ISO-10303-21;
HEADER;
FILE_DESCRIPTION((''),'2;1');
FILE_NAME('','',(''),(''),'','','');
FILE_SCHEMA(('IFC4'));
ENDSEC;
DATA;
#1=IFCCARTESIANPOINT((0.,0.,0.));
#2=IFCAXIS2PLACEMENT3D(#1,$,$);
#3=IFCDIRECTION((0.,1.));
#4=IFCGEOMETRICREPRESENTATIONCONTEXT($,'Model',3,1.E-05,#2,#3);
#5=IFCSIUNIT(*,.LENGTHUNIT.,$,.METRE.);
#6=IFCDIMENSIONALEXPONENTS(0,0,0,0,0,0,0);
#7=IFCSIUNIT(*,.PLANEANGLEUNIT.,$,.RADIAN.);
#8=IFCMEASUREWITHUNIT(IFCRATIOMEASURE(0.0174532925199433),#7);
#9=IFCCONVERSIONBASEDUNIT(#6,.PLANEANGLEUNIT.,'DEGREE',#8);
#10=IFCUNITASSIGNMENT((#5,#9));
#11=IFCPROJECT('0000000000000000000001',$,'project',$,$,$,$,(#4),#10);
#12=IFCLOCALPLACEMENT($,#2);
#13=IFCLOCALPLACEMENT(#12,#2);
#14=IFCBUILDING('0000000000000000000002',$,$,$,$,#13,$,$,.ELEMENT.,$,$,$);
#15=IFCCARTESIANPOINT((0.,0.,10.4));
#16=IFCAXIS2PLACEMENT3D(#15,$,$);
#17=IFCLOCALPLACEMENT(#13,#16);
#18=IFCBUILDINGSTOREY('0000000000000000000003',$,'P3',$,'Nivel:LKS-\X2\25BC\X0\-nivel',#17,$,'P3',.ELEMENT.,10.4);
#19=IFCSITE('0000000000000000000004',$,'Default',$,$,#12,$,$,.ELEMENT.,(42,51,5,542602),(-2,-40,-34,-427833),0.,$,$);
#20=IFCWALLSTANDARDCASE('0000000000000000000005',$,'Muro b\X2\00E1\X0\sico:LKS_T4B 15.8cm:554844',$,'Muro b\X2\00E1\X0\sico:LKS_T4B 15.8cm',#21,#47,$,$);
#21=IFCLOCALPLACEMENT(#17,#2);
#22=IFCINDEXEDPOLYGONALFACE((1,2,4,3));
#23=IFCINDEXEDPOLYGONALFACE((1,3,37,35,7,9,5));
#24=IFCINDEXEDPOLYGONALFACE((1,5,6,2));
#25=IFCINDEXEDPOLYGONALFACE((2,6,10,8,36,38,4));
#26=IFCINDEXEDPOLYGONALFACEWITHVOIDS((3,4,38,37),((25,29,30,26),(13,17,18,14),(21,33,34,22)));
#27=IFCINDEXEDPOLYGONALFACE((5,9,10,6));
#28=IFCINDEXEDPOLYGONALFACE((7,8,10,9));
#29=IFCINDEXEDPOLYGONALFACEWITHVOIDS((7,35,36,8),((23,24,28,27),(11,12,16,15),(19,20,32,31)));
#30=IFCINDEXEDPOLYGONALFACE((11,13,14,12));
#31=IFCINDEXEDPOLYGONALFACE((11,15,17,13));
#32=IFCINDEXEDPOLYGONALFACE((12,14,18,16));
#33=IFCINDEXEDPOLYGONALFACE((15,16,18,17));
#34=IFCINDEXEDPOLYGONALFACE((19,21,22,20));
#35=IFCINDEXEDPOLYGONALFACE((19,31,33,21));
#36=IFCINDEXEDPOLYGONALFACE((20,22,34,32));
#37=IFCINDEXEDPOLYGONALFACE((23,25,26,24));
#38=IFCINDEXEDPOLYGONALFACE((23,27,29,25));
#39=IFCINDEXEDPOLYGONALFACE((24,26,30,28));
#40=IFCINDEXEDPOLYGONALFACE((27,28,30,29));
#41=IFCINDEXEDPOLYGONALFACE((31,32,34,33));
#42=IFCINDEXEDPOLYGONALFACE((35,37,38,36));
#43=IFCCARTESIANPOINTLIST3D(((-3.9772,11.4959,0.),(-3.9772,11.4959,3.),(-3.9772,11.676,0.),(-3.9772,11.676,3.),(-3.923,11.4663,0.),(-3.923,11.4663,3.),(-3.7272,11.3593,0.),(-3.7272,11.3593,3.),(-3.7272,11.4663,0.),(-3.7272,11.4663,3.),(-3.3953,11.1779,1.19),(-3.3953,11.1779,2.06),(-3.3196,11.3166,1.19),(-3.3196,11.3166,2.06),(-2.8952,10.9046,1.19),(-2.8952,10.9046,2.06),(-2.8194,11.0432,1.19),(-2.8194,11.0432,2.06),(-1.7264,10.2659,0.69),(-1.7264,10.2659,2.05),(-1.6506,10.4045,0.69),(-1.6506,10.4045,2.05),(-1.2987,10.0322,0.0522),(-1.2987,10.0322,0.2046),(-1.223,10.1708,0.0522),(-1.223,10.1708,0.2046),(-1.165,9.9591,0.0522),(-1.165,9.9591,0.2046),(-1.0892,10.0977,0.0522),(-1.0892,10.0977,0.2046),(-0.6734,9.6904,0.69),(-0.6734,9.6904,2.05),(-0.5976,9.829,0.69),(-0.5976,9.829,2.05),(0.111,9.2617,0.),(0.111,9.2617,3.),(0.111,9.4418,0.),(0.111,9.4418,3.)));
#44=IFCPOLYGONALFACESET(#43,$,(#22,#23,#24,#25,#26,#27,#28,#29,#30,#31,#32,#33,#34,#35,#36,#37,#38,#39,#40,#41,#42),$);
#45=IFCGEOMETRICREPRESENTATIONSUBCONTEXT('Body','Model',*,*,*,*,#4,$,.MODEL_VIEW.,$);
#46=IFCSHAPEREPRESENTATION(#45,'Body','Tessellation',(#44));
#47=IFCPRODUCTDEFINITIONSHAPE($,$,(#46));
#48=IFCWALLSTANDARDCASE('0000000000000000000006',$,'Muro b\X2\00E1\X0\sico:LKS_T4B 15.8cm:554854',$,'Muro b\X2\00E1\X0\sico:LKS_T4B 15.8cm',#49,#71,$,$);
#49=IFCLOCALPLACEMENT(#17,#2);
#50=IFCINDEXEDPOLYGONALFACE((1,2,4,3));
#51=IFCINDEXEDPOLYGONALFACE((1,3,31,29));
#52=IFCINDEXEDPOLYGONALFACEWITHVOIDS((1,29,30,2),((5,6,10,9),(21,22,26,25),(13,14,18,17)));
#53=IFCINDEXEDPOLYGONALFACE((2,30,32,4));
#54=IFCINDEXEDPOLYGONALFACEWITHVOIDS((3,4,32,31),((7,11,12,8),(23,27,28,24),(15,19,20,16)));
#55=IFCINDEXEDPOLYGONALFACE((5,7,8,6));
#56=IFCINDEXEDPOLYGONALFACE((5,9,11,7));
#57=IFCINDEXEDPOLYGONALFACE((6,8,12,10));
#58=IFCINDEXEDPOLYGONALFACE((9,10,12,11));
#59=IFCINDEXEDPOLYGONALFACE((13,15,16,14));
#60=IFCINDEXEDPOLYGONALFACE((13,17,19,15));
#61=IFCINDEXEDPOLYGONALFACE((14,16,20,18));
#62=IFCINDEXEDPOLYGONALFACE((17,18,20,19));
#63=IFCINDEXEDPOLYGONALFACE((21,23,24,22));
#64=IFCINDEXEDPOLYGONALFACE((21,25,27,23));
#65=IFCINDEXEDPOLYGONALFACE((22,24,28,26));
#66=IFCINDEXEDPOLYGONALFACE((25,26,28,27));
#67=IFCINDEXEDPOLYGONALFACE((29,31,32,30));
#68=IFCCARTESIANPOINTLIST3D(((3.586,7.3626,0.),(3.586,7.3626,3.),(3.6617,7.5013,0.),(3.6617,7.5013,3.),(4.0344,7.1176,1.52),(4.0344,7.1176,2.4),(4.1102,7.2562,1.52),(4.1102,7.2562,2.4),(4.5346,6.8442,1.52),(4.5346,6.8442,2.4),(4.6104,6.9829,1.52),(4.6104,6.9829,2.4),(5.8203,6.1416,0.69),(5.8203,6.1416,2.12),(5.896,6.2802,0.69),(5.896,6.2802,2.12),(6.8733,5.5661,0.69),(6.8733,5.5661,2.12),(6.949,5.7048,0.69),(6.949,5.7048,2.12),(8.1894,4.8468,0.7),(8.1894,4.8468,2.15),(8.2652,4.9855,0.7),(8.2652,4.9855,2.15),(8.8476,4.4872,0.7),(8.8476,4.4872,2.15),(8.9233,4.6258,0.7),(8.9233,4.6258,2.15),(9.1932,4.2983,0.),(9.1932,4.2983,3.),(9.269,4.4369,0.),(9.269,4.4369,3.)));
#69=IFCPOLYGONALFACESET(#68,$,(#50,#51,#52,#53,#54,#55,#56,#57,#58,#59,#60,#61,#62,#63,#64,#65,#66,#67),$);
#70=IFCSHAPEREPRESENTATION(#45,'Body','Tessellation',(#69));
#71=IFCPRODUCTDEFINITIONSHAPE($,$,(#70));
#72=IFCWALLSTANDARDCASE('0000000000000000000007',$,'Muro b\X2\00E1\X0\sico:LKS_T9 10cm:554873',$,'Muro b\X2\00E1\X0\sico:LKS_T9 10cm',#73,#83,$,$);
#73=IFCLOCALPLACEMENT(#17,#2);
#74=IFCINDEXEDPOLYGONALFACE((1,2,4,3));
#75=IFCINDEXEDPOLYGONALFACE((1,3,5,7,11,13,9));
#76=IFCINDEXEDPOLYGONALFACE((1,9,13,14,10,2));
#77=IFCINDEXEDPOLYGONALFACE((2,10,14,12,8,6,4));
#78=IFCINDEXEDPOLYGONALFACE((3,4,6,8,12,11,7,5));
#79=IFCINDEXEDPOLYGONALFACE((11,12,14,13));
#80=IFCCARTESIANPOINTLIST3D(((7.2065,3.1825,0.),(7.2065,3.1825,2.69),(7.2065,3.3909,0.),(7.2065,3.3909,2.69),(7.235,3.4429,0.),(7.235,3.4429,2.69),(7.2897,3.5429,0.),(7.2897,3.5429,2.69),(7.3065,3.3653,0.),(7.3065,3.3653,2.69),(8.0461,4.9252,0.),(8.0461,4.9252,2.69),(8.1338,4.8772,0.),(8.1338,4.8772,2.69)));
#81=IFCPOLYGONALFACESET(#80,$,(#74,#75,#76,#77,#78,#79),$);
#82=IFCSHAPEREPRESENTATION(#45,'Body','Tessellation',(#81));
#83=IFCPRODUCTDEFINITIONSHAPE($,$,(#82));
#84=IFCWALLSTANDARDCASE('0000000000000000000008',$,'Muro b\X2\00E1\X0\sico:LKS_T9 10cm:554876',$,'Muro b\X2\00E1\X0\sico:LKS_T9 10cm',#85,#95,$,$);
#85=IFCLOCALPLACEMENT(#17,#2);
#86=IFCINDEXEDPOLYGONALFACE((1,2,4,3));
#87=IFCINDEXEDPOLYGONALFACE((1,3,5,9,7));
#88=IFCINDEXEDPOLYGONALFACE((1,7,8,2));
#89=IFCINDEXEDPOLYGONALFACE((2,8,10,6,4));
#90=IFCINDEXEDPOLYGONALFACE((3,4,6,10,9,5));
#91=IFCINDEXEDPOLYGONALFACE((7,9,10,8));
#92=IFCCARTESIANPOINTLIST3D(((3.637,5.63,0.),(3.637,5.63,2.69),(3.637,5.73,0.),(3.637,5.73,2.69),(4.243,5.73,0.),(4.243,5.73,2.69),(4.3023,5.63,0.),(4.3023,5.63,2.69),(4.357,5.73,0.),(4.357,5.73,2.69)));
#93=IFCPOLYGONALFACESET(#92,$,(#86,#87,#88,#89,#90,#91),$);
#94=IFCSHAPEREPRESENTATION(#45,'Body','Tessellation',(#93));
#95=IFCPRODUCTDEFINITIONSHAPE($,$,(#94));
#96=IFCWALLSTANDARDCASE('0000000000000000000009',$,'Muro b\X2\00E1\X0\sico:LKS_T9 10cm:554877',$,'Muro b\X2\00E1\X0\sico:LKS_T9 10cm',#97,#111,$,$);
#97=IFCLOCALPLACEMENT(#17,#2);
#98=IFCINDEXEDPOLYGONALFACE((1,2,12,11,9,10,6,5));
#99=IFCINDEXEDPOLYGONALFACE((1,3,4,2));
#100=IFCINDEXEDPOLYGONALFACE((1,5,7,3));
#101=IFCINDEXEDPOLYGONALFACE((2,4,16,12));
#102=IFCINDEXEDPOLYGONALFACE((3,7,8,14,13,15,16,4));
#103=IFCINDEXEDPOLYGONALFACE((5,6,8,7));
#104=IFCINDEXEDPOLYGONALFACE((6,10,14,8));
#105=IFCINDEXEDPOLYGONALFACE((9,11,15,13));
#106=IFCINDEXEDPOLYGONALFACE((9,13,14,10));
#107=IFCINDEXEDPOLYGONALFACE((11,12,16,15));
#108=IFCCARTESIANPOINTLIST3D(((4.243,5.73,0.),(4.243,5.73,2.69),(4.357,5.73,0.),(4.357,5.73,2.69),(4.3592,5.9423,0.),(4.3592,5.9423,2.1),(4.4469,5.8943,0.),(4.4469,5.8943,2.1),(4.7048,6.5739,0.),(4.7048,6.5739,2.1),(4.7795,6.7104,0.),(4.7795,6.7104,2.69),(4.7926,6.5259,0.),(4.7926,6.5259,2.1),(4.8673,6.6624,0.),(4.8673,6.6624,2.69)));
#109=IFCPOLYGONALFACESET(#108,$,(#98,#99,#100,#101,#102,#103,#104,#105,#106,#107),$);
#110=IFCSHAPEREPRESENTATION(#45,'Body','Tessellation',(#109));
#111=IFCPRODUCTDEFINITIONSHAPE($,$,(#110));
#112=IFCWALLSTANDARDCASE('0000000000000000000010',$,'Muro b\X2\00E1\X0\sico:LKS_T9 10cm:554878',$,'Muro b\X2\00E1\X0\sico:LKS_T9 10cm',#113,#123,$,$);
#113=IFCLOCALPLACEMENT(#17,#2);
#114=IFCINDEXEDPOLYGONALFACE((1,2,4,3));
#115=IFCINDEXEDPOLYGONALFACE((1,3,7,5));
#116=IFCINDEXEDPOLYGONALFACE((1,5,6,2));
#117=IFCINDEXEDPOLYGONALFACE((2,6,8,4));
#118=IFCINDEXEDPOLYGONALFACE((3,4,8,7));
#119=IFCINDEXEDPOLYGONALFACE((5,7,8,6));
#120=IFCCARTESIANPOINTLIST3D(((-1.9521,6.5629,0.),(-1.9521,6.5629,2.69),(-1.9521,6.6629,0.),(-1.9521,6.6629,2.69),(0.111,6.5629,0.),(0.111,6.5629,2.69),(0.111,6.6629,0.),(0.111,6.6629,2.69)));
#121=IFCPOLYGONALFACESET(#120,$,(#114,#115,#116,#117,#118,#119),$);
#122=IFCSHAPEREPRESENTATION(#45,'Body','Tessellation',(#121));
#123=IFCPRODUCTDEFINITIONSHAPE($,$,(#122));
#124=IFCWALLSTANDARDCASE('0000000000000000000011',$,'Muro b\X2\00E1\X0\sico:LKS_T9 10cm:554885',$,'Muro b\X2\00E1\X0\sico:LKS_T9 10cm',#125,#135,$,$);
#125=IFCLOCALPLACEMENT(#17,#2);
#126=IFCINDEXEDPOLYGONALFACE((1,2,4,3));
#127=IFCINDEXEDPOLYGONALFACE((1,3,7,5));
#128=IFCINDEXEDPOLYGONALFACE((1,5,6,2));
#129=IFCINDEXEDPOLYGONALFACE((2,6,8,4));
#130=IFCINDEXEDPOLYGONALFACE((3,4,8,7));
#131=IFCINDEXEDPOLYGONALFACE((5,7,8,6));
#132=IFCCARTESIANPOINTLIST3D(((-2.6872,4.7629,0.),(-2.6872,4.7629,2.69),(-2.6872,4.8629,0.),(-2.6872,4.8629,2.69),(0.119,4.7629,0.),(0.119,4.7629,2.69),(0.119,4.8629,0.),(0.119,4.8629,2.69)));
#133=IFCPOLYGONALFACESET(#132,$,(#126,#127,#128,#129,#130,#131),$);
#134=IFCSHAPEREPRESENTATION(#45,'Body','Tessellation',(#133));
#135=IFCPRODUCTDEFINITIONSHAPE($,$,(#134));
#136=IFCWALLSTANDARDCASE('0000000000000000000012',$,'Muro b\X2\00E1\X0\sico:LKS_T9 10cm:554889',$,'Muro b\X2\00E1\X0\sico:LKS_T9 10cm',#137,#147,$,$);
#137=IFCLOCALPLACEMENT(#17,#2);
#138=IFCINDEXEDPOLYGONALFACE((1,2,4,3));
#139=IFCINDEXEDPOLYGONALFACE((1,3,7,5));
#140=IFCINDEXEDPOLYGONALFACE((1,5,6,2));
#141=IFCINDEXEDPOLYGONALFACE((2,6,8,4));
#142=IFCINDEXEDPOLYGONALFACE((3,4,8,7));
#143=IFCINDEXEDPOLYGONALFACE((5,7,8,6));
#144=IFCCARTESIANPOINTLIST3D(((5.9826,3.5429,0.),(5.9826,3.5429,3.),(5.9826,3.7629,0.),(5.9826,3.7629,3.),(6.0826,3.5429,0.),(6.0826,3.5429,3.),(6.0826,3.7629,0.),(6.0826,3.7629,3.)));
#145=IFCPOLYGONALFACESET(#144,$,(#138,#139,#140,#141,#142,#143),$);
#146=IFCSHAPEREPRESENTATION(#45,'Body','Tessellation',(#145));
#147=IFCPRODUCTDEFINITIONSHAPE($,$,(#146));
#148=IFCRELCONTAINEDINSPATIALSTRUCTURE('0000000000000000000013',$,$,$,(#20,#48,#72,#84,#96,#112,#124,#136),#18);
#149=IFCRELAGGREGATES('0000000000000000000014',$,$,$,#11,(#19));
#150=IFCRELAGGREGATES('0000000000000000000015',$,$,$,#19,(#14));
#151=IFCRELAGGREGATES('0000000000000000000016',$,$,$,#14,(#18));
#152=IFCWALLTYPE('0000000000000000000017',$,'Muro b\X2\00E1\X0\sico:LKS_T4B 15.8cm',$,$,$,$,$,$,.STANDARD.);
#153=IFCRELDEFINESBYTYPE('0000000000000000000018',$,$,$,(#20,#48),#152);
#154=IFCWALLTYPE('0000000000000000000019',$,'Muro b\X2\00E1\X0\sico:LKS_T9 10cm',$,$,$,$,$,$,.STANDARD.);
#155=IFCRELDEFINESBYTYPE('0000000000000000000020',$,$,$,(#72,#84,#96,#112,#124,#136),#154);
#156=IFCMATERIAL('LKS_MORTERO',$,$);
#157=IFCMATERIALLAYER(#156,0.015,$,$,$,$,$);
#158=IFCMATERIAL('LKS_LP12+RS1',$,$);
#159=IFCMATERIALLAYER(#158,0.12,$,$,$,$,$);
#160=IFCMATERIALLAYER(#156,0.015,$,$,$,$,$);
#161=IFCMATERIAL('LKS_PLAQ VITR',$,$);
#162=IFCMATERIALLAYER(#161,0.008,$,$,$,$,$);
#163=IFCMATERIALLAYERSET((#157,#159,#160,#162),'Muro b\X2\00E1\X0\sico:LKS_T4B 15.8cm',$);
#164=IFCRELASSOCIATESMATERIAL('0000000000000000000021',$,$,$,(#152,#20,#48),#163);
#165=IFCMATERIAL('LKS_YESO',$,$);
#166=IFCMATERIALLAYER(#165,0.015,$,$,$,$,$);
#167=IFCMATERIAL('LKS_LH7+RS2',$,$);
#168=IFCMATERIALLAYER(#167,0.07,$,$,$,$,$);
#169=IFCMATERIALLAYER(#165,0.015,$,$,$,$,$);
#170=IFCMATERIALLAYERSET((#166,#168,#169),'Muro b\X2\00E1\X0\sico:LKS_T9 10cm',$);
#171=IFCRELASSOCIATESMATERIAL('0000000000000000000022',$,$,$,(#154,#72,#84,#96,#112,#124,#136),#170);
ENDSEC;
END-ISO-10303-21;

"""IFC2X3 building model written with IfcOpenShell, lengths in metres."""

from ifc_helpers import new_model, entity, si_unit, converted_unit, direction, frame, frame_2d, origin, place, context, subcontext, project, spatial, polyline, rectangle, outline, extrude, clip, bounded_halfspace, material, layer, layer_set, layer_usage, type_object, element, save


model = new_model("IFC2X3")

# Units and contexts
model_context = context("Model", 3, precision=1e-05, world=origin(), true_north=direction((0.0, 1.0)))
body_context = subcontext(model_context, "Body", "Model", "MODEL_VIEW")
ifc_project = project(units=[si_unit("LENGTHUNIT", "METRE"), converted_unit("PLANEANGLEUNIT", "DEGREE", entity("IfcRatioMeasure", 0.0174532925199433), si_unit("PLANEANGLEUNIT", "RADIAN"), dimensions=[0, 0, 0, 0, 0, 0, 0])], contexts=[model_context])

# Site, building, storey
site_placement = place(None, origin())
site = spatial("IfcSite", under=ifc_project, at=site_placement, Name="Default", CompositionType="ELEMENT", RefLatitude=(42, 51, 5, 542602), RefLongitude=(-2, -40, -34, -427833), RefElevation=0.0)
building_placement = place(site_placement, origin())
building = spatial("IfcBuilding", under=site, at=building_placement, CompositionType="ELEMENT")
storey_placement = place(building_placement, frame((0.0, 0.0, 10.4)))
storey = spatial("IfcBuildingStorey", under=building, at=storey_placement, Name="P3", ObjectType="Nivel:LKS-▼-nivel", LongName="P3", CompositionType="ELEMENT", Elevation=10.4)

# Walls, openings
ifc_material_1 = material(Name="LKS_MORTERO")
ifc_layer_1 = layer(ifc_material_1, 0.015)
ifc_material_2 = material(Name="LKS_LP12+RS1")
ifc_layer_2 = layer(ifc_material_2, 0.12)
ifc_layer_3 = layer(ifc_material_1, 0.015)
ifc_material_3 = material(Name="LKS_PLAQ VITR")
ifc_layer_4 = layer(ifc_material_3, 0.008)
ifc_layer_set_1 = layer_set([ifc_layer_1, ifc_layer_2, ifc_layer_3, ifc_layer_4], Name="Muro básico:LKS_T4B 15.8cm")
ifc_layer_usage_1 = layer_usage(ifc_layer_set_1, "AXIS2", "NEGATIVE", 0.079)
wall_type_1 = type_object("IfcWallType", Name="Muro básico:LKS_T4B 15.8cm", PredefinedType="STANDARD", material=ifc_layer_set_1)
wall_1_placement = place(storey_placement, frame((0.1488, 9.3311, 0.0), z_axis=(0.0, 0.0, 1.0), x_axis=(-0.877509, 0.479561, 0.0)))
wall_1 = element("IfcWallStandardCase", 1, at=wall_1_placement, inside=storey, type_object=wall_type_1, material=ifc_layer_usage_1, Name="Muro básico:LKS_T4B 15.8cm:554844", ObjectType="Muro básico:LKS_T4B 15.8cm", context=body_context, shape_type="Clipping", body=[
    clip(clip(extrude(outline(polyline([(4.7451, -0.079), (4.6588, 0.079), (4.5971, 0.079), (4.4252, -0.0149), (4.3739, 0.079), (2.8965, 0.079), (2.7965, 0.079), (0.0, 0.079), (0.0863, -0.079), (4.7451, -0.079)])), origin(), (0.0, 0.0, 1.0), 3.0), bounded_halfspace(frame((4.4252, -0.0149, 3.0), z_axis=(-0.877509, -0.479561, 0.0), x_axis=(0.0, 0.0, -1.0)), True, frame((4.4252, -0.0149, 3.0), z_axis=(-0.877509, -0.479561, 0.0), x_axis=(0.0, 0.0, -1.0)), polyline([(0.0, 0.0), (0.0, -0.107), (3.0, -0.107), (3.0, 0.0), (0.33, 0.0), (0.0, 0.0)]))), bounded_halfspace(frame((4.4252, -0.0149, 0.0), z_axis=(0.479561, -0.877509, 0.0), x_axis=(0.0, 0.0, -1.0)), True, frame((4.4252, -0.0149, 0.0), z_axis=(0.479561, -0.877509, 0.0), x_axis=(0.0, 0.0, -1.0)), polyline([(0.0, 0.0), (0.0, 0.1959), (-3.0, 0.1959), (-3.0, 0.0), (-2.67, 0.0), (0.0, 0.0)]))),
])
opening_1_placement = place(wall_1_placement, origin())
element("IfcOpeningElement", 2, at=opening_1_placement, cuts=wall_1, ObjectType="Opening", context=body_context, shape_type="SweptSolid", body=[
    extrude(rectangle(XDim=0.1524, YDim=0.1524, at=frame_2d((0.0, 0.0), x_axis=(0.0, 1.0))), frame((1.5303, -1.445, 0.1284), z_axis=(0.0, 1.0, 0.0), x_axis=(-1.0, 0.0, 0.0)), (0.0, 0.0, 1.0), 3.048),
])
opening_2_placement = place(wall_1_placement, frame((2.0939, 0.079, 0.69)))
element("IfcOpeningElement", 3, at=opening_2_placement, cuts=wall_1, ObjectType="Opening", context=body_context, shape_type="SweptSolid", body=[
    extrude(rectangle(XDim=1.36, YDim=1.2, at=frame_2d((0.68, 0.6), x_axis=(1.0, 0.0))), frame((0.0, 0.0, 0.0), z_axis=(0.0, -1.0, 0.0), x_axis=(0.0, 0.0, 1.0)), (0.0, 0.0, 1.0), 0.158),
])
opening_3_placement = place(wall_1_placement, frame((3.9957, 0.079, 1.19)))
element("IfcOpeningElement", 4, at=opening_3_placement, cuts=wall_1, ObjectType="Opening", context=body_context, shape_type="SweptSolid", body=[
    extrude(rectangle(XDim=0.87, YDim=0.57, at=frame_2d((0.435, 0.285), x_axis=(1.0, 0.0))), frame((0.0, 0.0, 0.0), z_axis=(0.0, -1.0, 0.0), x_axis=(0.0, 0.0, 1.0)), (0.0, 0.0, 1.0), 0.158),
])
ifc_layer_usage_2 = layer_usage(ifc_layer_set_1, "AXIS2", "POSITIVE", -0.079)
wall_2_placement = place(storey_placement, frame((9.2311, 4.3676, 0.0), z_axis=(0.0, 0.0, 1.0), x_axis=(-0.877509, 0.479561, 0.0)))
wall_2 = element("IfcWallStandardCase", 5, at=wall_2_placement, inside=storey, type_object=wall_type_1, material=ifc_layer_usage_2, Name="Muro básico:LKS_T4B 15.8cm:554854", ObjectType="Muro básico:LKS_T4B 15.8cm", context=body_context, shape_type="Clipping", body=[
    clip(clip(extrude(rectangle(XDim=6.39, YDim=0.158, at=frame_2d((3.195, 0.0), x_axis=(-1.0, 0.0))), origin(), (0.0, 0.0, 1.0), 3.0), bounded_halfspace(frame((6.39, -0.079, 3.0), z_axis=(-1.0, 0.0, 0.0), x_axis=(0.0, 0.0, -1.0)), True, frame((6.39, -0.079, 3.0), z_axis=(-1.0, 0.0, 0.0), x_axis=(0.0, 0.0, -1.0)), polyline([(0.0, 0.0), (0.0, -0.0455), (0.0, -0.158), (3.0, -0.158), (3.0, 0.0), (0.0, 0.0)]))), bounded_halfspace(frame((0.0, -0.079, 0.0), z_axis=(1.0, 0.0, 0.0), x_axis=(0.0, 0.0, -1.0)), True, frame((0.0, -0.079, 0.0), z_axis=(1.0, 0.0, 0.0), x_axis=(0.0, 0.0, -1.0)), polyline([(0.0, 0.0), (0.0, 0.158), (-3.0, 0.158), (-3.0, 0.0488), (-3.0, 0.0), (0.0, 0.0)]))),
])
opening_4_placement = place(wall_2_placement, frame((3.8438, 0.079, 0.69)))
element("IfcOpeningElement", 6, at=opening_4_placement, cuts=wall_2, ObjectType="Opening", context=body_context, shape_type="SweptSolid", body=[
    extrude(rectangle(XDim=1.43, YDim=1.2, at=frame_2d((0.715, 0.6), x_axis=(1.0, 0.0))), frame((0.0, 0.0, 0.0), z_axis=(0.0, -1.0, 0.0), x_axis=(0.0, 0.0, 1.0)), (0.0, 0.0, 1.0), 0.158),
])
opening_5_placement = place(wall_2_placement, frame((5.8789, 0.079, 1.52)))
element("IfcOpeningElement", 7, at=opening_5_placement, cuts=wall_2, ObjectType="Opening", context=body_context, shape_type="SweptSolid", body=[
    extrude(rectangle(XDim=0.88, YDim=0.57, at=frame_2d((0.44, 0.285), x_axis=(1.0, 0.0))), frame((0.0, 0.0, 0.0), z_axis=(0.0, -1.0, 0.0), x_axis=(0.0, 0.0, 1.0)), (0.0, 0.0, 1.0), 0.158),
])
opening_6_placement = place(wall_2_placement, frame((1.1439, 0.079, 0.7)))
element("IfcOpeningElement", 8, at=opening_6_placement, cuts=wall_2, ObjectType="Opening", context=body_context, shape_type="SweptSolid", body=[
    extrude(rectangle(XDim=1.45, YDim=0.75, at=frame_2d((0.725, 0.375), x_axis=(1.0, 0.0))), frame((0.0, 0.0, 0.0), z_axis=(0.0, -1.0, 0.0), x_axis=(0.0, 0.0, 1.0)), (0.0, 0.0, 1.0), 0.158),
])

# Walls
ifc_material_4 = material(Name="LKS_YESO")
ifc_layer_5 = layer(ifc_material_4, 0.015)
ifc_material_5 = material(Name="LKS_LH7+RS2")
ifc_layer_6 = layer(ifc_material_5, 0.07)
ifc_layer_7 = layer(ifc_material_4, 0.015)
ifc_layer_set_2 = layer_set([ifc_layer_5, ifc_layer_6, ifc_layer_7], Name="Muro básico:LKS_T9 10cm")
ifc_layer_usage_3 = layer_usage(ifc_layer_set_2, "AXIS2", "NEGATIVE", 0.05)
wall_type_2 = type_object("IfcWallType", Name="Muro básico:LKS_T9 10cm", PredefinedType="STANDARD", material=ifc_layer_set_2)
wall_3_placement = place(storey_placement, frame((8.09, 4.9012, 0.0), z_axis=(0.0, 0.0, 1.0), x_axis=(-0.480022, -0.877256, 0.0)))
element("IfcWallStandardCase", 9, at=wall_3_placement, inside=storey, type_object=wall_type_2, material=ifc_layer_usage_3, Name="Muro básico:LKS_T9 10cm:554873", ObjectType="Muro básico:LKS_T9 10cm", context=body_context, shape_type="SweptSolid", body=[
    extrude(outline(polyline([(1.749, -0.05), (1.9318, 0.05), (1.7235, 0.05), (0.0, 0.05), (0.0001, -0.05), (1.5758, -0.05), (1.6897, -0.05), (1.749, -0.05)])), origin(), (0.0, 0.0, 1.0), 2.69),
])
ifc_layer_usage_4 = layer_usage(ifc_layer_set_2, "AXIS2", "NEGATIVE", 0.05)
wall_4_placement = place(storey_placement, frame((3.637, 5.68, 0.0)))
element("IfcWallStandardCase", 10, at=wall_4_placement, inside=storey, type_object=wall_type_2, material=ifc_layer_usage_4, Name="Muro básico:LKS_T9 10cm:554876", ObjectType="Muro básico:LKS_T9 10cm", context=body_context, shape_type="SweptSolid", body=[
    extrude(outline(polyline([(0.6654, -0.05), (0.7201, 0.05), (0.6061, 0.05), (0.0, 0.05), (0.0, -0.05), (0.6654, -0.05)])), origin(), (0.0, 0.0, 1.0), 2.69),
])

# Wall, opening
ifc_layer_usage_5 = layer_usage(ifc_layer_set_2, "AXIS2", "NEGATIVE", 0.05)
wall_5_placement = place(storey_placement, frame((4.2869, 5.706, 0.0), z_axis=(0.0, 0.0, 1.0), x_axis=(0.480022, 0.877256, 0.0)))
wall_5 = element("IfcWallStandardCase", 11, at=wall_5_placement, inside=storey, type_object=wall_type_2, material=ifc_layer_usage_5, Name="Muro básico:LKS_T9 10cm:554877", ObjectType="Muro básico:LKS_T9 10cm", context=body_context, shape_type="SweptSolid", body=[
    extrude(outline(polyline([(0.0547, -0.05), (1.1176, -0.05), (1.1176, 0.05), (0.0, 0.05), (0.0547, -0.05)])), origin(), (0.0, 0.0, 1.0), 2.69),
])
opening_7_placement = place(wall_5_placement, frame((0.962, 0.05, 0.0)))
element("IfcOpeningElement", 12, at=opening_7_placement, cuts=wall_5, ObjectType="Opening", context=body_context, shape_type="SweptSolid", body=[
    extrude(rectangle(XDim=2.1, YDim=0.72, at=frame_2d((1.05, 0.36), x_axis=(1.0, 0.0))), frame((0.0, 0.0, 0.0), z_axis=(0.0, -1.0, 0.0), x_axis=(0.0, 0.0, 1.0)), (0.0, 0.0, 1.0), 0.1),
])

# Walls
ifc_layer_usage_6 = layer_usage(ifc_layer_set_2, "AXIS2", "NEGATIVE", 0.05)
wall_6_placement = place(storey_placement, frame((0.111, 6.6129, 0.0), z_axis=(0.0, 0.0, 1.0), x_axis=(-1.0, 0.0, 0.0)))
element("IfcWallStandardCase", 13, at=wall_6_placement, inside=storey, type_object=wall_type_2, material=ifc_layer_usage_6, Name="Muro básico:LKS_T9 10cm:554878", ObjectType="Muro básico:LKS_T9 10cm", context=body_context, shape_type="SweptSolid", body=[
    extrude(rectangle(XDim=2.0631, YDim=0.1, at=frame_2d((1.0315, 0.0), x_axis=(-1.0, 0.0))), origin(), (0.0, 0.0, 1.0), 2.69),
])
ifc_layer_usage_7 = layer_usage(ifc_layer_set_2, "AXIS2", "NEGATIVE", 0.05)
wall_7_placement = place(storey_placement, frame((0.119, 4.8129, 0.0), z_axis=(0.0, 0.0, 1.0), x_axis=(-1.0, 0.0, 0.0)))
element("IfcWallStandardCase", 14, at=wall_7_placement, inside=storey, type_object=wall_type_2, material=ifc_layer_usage_7, Name="Muro básico:LKS_T9 10cm:554885", ObjectType="Muro básico:LKS_T9 10cm", context=body_context, shape_type="SweptSolid", body=[
    extrude(rectangle(XDim=2.8061, YDim=0.1, at=frame_2d((1.4031, 0.0), x_axis=(-1.0, 0.0))), origin(), (0.0, 0.0, 1.0), 2.69),
])
ifc_layer_usage_8 = layer_usage(ifc_layer_set_2, "AXIS2", "NEGATIVE", 0.05)
wall_8_placement = place(storey_placement, frame((6.0326, 3.5429, 0.0), z_axis=(0.0, 0.0, 1.0), x_axis=(0.0, 1.0, 0.0)))
element("IfcWallStandardCase", 15, at=wall_8_placement, inside=storey, type_object=wall_type_2, material=ifc_layer_usage_8, Name="Muro básico:LKS_T9 10cm:554889", ObjectType="Muro básico:LKS_T9 10cm", context=body_context, shape_type="SweptSolid", body=[
    extrude(rectangle(XDim=0.22, YDim=0.1, at=frame_2d((0.11, 0.0), x_axis=(-1.0, 0.0))), origin(), (0.0, 0.0, 1.0), 3.0),
])

save(model, "model.ifc")
